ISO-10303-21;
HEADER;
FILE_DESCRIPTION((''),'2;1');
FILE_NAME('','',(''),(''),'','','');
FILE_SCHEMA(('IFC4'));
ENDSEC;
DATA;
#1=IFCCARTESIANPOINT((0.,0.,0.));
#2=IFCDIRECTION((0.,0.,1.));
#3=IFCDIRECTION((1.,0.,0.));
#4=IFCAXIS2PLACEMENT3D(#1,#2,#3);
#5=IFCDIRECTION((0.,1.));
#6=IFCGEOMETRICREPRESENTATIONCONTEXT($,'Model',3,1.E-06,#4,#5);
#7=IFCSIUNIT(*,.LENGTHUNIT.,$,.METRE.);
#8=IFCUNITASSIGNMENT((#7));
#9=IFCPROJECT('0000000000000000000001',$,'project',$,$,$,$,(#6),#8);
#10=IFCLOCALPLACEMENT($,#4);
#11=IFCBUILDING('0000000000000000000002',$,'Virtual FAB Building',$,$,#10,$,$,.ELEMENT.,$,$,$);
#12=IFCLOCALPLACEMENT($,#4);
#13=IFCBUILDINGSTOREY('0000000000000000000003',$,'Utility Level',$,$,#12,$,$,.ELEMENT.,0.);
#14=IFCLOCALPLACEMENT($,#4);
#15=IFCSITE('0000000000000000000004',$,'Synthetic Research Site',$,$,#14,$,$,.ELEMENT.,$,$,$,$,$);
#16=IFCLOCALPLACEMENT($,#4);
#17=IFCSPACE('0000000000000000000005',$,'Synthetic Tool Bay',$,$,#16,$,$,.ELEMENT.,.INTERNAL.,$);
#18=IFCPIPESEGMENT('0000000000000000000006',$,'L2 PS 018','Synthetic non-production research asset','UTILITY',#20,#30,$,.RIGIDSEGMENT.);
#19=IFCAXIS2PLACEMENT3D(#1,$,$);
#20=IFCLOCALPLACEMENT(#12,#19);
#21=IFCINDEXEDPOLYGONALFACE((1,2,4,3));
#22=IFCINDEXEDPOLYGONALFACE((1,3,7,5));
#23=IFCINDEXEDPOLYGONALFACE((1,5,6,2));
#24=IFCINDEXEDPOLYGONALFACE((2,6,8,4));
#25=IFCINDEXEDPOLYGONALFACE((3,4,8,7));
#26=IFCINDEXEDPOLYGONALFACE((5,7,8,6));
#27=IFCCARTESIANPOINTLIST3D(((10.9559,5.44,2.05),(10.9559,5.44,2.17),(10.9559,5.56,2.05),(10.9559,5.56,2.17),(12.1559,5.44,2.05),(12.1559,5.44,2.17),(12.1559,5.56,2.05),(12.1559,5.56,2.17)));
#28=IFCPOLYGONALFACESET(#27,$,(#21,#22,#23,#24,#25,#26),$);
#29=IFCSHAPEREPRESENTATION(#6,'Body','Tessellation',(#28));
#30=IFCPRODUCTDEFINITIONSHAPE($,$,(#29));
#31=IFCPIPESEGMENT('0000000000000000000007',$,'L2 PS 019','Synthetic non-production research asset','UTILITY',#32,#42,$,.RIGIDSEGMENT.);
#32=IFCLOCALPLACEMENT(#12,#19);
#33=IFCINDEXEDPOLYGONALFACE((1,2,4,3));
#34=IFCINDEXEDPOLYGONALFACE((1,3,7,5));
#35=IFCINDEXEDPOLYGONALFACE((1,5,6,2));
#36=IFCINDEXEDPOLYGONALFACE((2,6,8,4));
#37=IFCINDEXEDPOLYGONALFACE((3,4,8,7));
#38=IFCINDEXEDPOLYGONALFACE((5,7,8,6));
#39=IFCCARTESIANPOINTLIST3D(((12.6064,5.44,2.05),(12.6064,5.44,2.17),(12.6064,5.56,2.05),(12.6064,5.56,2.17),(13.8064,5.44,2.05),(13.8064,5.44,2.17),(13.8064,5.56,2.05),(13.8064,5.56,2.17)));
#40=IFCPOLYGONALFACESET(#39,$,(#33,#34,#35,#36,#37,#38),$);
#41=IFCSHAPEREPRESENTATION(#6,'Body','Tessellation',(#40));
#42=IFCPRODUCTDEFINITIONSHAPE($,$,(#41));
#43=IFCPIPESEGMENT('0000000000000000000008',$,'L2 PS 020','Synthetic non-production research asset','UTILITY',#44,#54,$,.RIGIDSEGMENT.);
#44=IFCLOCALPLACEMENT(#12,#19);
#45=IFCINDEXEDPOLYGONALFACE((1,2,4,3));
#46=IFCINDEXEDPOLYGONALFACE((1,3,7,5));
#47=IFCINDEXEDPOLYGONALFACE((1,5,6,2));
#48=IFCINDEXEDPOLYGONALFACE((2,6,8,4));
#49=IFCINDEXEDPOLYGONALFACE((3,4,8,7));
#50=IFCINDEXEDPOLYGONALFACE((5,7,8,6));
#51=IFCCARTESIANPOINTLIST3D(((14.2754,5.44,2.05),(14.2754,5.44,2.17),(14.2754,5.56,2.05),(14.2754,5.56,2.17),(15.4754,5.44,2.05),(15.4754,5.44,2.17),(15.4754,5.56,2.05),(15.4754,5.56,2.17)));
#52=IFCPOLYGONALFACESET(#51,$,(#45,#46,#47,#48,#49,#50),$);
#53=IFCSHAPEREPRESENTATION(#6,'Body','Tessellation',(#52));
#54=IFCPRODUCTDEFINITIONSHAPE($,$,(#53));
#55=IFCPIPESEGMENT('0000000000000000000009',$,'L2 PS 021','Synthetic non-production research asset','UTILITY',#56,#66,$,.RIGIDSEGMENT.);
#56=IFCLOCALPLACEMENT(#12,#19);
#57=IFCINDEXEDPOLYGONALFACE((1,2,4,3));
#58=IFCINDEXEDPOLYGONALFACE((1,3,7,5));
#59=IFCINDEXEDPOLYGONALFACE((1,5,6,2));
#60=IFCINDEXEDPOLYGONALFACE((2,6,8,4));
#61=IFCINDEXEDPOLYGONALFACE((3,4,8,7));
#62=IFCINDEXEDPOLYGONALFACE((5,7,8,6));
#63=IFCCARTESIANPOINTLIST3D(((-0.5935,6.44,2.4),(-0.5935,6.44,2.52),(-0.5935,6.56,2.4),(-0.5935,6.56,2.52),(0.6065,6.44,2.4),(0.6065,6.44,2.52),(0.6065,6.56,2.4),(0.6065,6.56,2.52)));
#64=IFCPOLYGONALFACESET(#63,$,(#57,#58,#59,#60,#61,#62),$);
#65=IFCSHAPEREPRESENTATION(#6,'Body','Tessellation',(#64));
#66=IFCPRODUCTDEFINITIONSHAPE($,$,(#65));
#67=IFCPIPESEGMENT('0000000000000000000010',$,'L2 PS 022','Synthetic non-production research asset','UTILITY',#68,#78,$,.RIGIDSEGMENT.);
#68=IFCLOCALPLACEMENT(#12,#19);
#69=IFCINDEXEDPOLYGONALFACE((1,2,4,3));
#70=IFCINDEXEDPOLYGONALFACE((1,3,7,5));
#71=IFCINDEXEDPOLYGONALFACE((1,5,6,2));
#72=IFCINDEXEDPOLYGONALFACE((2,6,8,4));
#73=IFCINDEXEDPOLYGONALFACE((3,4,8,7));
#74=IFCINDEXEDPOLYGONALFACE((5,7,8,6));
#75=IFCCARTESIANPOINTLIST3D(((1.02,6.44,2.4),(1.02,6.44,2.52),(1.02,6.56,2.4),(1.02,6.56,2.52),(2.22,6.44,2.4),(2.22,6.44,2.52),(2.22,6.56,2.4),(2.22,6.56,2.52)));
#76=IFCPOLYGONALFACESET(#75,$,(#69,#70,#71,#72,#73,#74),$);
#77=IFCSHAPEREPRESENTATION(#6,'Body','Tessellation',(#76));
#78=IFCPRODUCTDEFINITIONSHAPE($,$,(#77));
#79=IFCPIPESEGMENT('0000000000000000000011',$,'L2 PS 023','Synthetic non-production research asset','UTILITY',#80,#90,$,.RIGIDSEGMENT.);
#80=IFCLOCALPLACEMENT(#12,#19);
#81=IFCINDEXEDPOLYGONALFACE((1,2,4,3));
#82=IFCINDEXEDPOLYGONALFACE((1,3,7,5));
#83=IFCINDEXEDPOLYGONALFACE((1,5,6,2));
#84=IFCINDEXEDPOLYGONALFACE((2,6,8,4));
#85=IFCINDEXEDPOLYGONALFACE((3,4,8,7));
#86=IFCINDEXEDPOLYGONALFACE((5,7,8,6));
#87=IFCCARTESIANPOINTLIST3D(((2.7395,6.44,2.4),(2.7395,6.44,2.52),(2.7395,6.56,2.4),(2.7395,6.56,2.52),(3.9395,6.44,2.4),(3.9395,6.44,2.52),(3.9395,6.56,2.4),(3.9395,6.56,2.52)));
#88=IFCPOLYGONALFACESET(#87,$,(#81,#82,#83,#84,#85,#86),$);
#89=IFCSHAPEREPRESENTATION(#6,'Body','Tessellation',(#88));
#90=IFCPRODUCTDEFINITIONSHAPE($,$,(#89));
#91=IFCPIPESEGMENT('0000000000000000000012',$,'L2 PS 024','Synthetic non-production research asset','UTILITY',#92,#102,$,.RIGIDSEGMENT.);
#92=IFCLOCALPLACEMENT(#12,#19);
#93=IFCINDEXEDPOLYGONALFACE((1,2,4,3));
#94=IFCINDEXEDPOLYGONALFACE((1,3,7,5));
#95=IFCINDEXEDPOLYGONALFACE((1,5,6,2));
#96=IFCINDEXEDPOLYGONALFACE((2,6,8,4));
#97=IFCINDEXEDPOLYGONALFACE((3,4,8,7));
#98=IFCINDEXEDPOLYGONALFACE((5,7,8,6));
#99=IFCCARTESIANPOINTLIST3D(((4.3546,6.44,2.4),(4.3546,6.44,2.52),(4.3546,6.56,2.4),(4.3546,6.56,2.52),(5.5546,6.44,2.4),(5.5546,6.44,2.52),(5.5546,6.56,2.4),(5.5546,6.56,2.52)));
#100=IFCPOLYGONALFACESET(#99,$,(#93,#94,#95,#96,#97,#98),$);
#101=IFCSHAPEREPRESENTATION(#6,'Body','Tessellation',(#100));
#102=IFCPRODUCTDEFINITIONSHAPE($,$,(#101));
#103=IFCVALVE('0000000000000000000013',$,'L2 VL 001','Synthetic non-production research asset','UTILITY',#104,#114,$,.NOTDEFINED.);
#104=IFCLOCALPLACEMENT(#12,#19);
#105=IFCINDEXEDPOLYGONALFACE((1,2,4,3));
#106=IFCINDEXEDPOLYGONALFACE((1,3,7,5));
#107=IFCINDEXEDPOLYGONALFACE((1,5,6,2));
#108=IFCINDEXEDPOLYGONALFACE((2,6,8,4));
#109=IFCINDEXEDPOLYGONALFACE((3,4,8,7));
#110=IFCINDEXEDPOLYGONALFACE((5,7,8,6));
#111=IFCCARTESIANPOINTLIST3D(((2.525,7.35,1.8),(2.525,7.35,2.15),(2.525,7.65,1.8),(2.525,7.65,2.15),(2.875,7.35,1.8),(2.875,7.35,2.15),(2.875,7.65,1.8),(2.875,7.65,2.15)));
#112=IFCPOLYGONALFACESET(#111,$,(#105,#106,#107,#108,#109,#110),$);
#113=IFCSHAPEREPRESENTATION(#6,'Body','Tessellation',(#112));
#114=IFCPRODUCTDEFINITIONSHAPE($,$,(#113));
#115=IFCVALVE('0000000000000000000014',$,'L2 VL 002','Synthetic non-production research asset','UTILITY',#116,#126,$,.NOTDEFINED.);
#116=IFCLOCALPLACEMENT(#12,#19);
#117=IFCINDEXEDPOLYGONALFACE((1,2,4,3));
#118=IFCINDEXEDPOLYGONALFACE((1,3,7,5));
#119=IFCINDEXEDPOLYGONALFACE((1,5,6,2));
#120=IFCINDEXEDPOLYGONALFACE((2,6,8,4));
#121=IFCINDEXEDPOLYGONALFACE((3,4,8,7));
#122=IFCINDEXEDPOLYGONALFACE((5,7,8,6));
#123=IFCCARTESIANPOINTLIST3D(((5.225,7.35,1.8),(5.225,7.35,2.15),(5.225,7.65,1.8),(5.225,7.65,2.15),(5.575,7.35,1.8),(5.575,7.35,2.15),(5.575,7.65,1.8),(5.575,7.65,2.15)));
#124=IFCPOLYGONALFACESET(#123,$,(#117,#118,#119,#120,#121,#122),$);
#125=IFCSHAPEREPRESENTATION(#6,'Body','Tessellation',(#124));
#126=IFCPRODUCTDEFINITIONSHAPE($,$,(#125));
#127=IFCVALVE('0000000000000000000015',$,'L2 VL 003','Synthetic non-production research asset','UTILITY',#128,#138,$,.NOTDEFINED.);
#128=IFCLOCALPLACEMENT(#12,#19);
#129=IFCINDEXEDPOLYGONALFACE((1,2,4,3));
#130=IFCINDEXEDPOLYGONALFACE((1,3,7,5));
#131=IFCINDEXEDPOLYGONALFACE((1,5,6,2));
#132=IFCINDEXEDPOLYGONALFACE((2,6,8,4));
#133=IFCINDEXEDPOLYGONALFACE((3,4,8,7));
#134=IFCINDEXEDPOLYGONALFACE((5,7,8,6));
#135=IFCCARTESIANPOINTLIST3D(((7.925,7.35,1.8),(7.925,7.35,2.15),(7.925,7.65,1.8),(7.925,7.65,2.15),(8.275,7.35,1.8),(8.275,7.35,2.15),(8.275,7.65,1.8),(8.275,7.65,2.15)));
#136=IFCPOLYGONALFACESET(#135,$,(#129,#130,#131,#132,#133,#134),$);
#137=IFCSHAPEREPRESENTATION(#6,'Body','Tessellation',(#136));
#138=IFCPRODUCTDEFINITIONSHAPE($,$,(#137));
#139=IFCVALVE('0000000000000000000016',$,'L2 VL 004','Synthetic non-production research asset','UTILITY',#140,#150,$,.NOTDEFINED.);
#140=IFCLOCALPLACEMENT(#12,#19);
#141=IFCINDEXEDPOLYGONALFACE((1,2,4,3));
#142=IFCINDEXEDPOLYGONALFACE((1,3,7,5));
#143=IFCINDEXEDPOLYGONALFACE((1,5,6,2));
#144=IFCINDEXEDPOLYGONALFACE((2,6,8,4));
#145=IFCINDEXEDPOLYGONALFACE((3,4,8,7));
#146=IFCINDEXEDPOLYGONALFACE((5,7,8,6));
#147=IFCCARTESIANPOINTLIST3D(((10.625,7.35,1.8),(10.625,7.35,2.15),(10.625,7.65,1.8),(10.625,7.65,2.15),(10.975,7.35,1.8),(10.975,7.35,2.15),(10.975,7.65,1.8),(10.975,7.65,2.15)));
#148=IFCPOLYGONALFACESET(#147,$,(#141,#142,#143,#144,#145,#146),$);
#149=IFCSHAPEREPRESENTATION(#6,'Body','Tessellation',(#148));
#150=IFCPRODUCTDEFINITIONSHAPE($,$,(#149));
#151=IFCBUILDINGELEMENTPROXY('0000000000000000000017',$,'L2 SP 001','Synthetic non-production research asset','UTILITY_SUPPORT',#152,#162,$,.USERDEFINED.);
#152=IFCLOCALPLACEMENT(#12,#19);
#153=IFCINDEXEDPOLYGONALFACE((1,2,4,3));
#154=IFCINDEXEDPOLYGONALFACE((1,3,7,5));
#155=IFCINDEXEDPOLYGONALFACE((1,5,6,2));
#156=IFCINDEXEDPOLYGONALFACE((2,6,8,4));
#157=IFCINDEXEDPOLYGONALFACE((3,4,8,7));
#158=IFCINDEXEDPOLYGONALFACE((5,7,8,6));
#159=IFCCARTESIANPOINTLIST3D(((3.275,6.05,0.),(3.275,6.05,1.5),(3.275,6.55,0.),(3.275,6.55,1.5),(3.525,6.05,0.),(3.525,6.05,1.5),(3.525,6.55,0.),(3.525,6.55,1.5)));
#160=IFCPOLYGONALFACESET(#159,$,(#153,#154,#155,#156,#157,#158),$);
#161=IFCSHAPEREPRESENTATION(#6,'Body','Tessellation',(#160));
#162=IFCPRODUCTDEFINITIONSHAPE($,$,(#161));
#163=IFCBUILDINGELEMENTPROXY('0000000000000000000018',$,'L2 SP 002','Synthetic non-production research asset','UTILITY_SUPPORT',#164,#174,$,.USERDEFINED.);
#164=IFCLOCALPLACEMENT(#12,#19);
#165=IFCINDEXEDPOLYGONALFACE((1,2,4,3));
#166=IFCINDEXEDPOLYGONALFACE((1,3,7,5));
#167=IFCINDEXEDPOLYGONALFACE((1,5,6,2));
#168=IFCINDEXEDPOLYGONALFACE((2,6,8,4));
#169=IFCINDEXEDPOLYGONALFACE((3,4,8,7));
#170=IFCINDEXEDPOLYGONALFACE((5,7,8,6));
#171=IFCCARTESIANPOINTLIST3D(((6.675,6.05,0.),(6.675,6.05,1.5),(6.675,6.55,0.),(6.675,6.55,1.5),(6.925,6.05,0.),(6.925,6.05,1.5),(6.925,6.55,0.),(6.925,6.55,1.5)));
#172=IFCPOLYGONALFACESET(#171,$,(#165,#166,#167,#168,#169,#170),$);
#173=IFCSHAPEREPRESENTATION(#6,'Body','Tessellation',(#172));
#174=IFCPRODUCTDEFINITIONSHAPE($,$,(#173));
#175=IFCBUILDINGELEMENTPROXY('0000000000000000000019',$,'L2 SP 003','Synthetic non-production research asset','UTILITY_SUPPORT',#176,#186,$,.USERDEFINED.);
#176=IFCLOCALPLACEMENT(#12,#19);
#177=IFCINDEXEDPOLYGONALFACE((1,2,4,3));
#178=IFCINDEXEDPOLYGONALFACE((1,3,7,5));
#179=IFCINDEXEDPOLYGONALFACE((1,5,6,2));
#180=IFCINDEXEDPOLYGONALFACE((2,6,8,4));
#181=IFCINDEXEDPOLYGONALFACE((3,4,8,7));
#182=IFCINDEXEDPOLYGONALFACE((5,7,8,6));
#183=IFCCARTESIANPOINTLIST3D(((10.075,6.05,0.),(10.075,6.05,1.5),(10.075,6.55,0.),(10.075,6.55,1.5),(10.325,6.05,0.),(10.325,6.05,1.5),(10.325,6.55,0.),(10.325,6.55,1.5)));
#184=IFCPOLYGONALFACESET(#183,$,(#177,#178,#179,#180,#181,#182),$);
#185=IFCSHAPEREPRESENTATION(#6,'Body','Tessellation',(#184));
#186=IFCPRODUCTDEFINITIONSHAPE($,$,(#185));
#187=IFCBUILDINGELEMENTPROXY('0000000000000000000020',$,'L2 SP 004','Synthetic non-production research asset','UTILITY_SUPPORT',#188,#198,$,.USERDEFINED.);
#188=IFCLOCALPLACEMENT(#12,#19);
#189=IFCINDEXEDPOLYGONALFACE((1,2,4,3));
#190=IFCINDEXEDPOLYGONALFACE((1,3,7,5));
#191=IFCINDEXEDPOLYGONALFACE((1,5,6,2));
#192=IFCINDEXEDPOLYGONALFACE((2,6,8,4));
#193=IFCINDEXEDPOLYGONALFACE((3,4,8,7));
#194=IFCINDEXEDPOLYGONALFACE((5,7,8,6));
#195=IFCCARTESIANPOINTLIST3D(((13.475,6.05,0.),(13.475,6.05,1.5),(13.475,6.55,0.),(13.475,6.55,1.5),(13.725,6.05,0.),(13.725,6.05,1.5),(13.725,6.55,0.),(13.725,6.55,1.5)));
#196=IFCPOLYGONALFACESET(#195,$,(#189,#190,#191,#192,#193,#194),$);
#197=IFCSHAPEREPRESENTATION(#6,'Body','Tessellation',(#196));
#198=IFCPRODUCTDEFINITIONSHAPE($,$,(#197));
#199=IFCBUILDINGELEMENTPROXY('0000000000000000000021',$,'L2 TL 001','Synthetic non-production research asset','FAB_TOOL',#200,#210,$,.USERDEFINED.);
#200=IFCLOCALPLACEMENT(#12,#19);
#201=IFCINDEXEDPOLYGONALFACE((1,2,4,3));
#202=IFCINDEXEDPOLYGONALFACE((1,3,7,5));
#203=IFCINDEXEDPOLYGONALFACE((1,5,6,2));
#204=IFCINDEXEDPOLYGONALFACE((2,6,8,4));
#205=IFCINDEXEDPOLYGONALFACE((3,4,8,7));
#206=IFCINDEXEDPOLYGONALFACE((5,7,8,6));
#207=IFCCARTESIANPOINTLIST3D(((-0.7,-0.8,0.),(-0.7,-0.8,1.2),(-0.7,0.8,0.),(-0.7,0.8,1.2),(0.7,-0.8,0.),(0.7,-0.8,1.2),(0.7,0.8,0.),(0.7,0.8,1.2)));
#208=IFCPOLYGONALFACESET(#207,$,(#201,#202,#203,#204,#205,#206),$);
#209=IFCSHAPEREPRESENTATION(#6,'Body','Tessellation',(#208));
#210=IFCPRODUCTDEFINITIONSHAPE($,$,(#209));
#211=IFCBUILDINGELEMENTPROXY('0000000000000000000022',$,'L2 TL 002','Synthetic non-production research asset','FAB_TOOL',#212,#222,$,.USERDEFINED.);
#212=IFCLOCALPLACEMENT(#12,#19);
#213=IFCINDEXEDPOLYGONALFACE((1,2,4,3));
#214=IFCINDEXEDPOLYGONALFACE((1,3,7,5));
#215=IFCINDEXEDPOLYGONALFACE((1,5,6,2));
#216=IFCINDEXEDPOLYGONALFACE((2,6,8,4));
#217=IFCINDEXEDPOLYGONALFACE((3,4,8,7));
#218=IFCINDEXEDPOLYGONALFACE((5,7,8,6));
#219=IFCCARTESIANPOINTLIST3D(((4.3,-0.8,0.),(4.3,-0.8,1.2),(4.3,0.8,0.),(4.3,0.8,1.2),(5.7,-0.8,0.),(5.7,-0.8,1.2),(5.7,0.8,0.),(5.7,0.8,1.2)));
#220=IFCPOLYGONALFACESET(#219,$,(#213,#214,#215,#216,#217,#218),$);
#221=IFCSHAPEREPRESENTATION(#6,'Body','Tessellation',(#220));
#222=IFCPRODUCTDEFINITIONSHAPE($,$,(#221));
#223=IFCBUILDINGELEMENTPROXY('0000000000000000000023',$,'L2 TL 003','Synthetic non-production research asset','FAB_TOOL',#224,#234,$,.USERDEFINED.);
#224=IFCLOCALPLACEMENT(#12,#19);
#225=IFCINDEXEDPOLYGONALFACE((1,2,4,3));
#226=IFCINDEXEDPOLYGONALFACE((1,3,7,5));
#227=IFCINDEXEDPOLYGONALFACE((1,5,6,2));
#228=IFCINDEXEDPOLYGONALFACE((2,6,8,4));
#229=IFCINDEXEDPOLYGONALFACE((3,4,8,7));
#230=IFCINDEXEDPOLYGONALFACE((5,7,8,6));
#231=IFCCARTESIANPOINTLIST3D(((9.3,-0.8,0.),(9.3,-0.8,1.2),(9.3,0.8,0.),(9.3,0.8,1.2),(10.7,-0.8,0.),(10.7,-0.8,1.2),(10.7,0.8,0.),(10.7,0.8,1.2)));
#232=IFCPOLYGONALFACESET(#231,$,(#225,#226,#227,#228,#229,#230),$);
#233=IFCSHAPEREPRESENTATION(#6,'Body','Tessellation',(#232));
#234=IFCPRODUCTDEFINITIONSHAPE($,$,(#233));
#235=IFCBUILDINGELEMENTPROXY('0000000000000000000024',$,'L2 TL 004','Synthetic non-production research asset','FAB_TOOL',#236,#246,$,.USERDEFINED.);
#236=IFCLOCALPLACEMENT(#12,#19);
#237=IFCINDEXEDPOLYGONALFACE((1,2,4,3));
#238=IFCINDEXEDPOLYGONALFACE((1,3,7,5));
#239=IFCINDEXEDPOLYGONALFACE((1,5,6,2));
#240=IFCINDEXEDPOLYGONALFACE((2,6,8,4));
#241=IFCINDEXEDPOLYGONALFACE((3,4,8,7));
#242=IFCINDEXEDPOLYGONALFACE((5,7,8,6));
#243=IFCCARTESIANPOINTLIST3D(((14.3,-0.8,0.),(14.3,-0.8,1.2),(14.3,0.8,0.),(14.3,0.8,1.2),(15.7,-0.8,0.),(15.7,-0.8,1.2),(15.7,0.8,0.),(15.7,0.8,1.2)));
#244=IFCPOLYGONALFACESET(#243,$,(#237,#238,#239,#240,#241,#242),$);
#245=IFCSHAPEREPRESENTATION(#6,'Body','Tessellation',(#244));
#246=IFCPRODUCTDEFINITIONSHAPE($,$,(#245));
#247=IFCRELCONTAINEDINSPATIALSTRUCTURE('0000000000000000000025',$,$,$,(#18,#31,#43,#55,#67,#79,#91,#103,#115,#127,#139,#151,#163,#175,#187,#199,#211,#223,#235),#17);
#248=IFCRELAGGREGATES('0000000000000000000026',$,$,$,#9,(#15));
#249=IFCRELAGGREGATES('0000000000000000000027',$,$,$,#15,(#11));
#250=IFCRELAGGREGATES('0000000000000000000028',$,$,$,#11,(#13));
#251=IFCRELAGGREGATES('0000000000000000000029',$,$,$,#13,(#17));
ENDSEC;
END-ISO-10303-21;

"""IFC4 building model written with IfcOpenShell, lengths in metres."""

from ifc_helpers import new_model, si_unit, direction, frame, origin_with_axes, origin_2d_with_axis, place, context, project, spatial, rectangle, extrude, element, save


model = new_model("IFC4")

# Units and contexts
model_context = context("Model", 3, precision=1e-06, world=origin_with_axes(), true_north=direction((0.0, 1.0)))
ifc_project = project(units=[si_unit("LENGTHUNIT", "METRE")], contexts=[model_context])

# Site, building, storey, space
site_placement = place(None, origin_with_axes())
site = spatial("IfcSite", under=ifc_project, at=site_placement, Name="Synthetic Research Site", CompositionType="ELEMENT")
building_placement = place(None, origin_with_axes())
building = spatial("IfcBuilding", under=site, at=building_placement, Name="Virtual FAB Building", CompositionType="ELEMENT")
storey_placement = place(None, origin_with_axes())
storey = spatial("IfcBuildingStorey", under=building, at=storey_placement, Name="Utility Level", CompositionType="ELEMENT", Elevation=0.0)
space_placement = place(None, origin_with_axes())
space = spatial("IfcSpace", under=storey, at=space_placement, Name="Synthetic Tool Bay", CompositionType="ELEMENT", PredefinedType="INTERNAL")

# Pipe segments
for number, where, z_axis, x_axis, name in (
    (1, (11.5559, 5.5, 2.05), (0.0, 0.0, 1.0), (1.0, 0.0, 0.0), "L2 PS 018"),
    (2, (13.2064, 5.5, 2.05), (0.0, 0.0, 1.0), (1.0, 0.0, 0.0), "L2 PS 019"),
    (3, (14.8754, 5.5, 2.05), (0.0, 0.0, 1.0), (1.0, 0.0, 0.0), "L2 PS 020"),
    (4, (0.0065, 6.5, 2.4), (0.0, 0.0, 1.0), (1.0, 0.0, 0.0), "L2 PS 021"),
    (5, (1.62, 6.5, 2.4), (0.0, 0.0, 1.0), (1.0, 0.0, 0.0), "L2 PS 022"),
    (6, (3.3395, 6.5, 2.4), (0.0, 0.0, 1.0), (1.0, 0.0, 0.0), "L2 PS 023"),
    (7, (4.9546, 6.5, 2.4), (0.0, 0.0, 1.0), (1.0, 0.0, 0.0), "L2 PS 024"),
):
    element("IfcPipeSegment", number, at=place(None, frame(where, z_axis=z_axis, x_axis=x_axis)), inside=space, Name=name, Description="Synthetic non-production research asset", ObjectType="UTILITY", PredefinedType="RIGIDSEGMENT", context=model_context, shape_type="SweptSolid", body=[
        extrude(rectangle(XDim=1.2, YDim=0.12, at=origin_2d_with_axis()), origin_with_axes(), (0.0, 0.0, 1.0), 0.12),
    ])

# Valves
for number, where, z_axis, x_axis, name in (
    (8, (2.7, 7.5, 1.8), (0.0, 0.0, 1.0), (1.0, 0.0, 0.0), "L2 VL 001"),
    (9, (5.4, 7.5, 1.8), (0.0, 0.0, 1.0), (1.0, 0.0, 0.0), "L2 VL 002"),
    (10, (8.1, 7.5, 1.8), (0.0, 0.0, 1.0), (1.0, 0.0, 0.0), "L2 VL 003"),
    (11, (10.8, 7.5, 1.8), (0.0, 0.0, 1.0), (1.0, 0.0, 0.0), "L2 VL 004"),
):
    element("IfcValve", number, at=place(None, frame(where, z_axis=z_axis, x_axis=x_axis)), inside=space, Name=name, Description="Synthetic non-production research asset", ObjectType="UTILITY", PredefinedType="NOTDEFINED", context=model_context, shape_type="SweptSolid", body=[
        extrude(rectangle(XDim=0.35, YDim=0.3, at=origin_2d_with_axis()), origin_with_axes(), (0.0, 0.0, 1.0), 0.35),
    ])

# Building element proxies
for number, where, z_axis, x_axis, name in (
    (12, (3.4, 6.3, 0.0), (0.0, 0.0, 1.0), (1.0, 0.0, 0.0), "L2 SP 001"),
    (13, (6.8, 6.3, 0.0), (0.0, 0.0, 1.0), (1.0, 0.0, 0.0), "L2 SP 002"),
    (14, (10.2, 6.3, 0.0), (0.0, 0.0, 1.0), (1.0, 0.0, 0.0), "L2 SP 003"),
    (15, (13.6, 6.3, 0.0), (0.0, 0.0, 1.0), (1.0, 0.0, 0.0), "L2 SP 004"),
):
    element("IfcBuildingElementProxy", number, at=place(None, frame(where, z_axis=z_axis, x_axis=x_axis)), inside=space, Name=name, Description="Synthetic non-production research asset", ObjectType="UTILITY_SUPPORT", PredefinedType="USERDEFINED", context=model_context, shape_type="SweptSolid", body=[
        extrude(rectangle(XDim=0.25, YDim=0.5, at=origin_2d_with_axis()), origin_with_axes(), (0.0, 0.0, 1.0), 1.5),
    ])
for number, where, z_axis, x_axis, name in (
    (16, (0.0, 0.0, 0.0), (0.0, 0.0, 1.0), (1.0, 0.0, 0.0), "L2 TL 001"),
    (17, (5.0, 0.0, 0.0), (0.0, 0.0, 1.0), (1.0, 0.0, 0.0), "L2 TL 002"),
    (18, (10.0, 0.0, 0.0), (0.0, 0.0, 1.0), (1.0, 0.0, 0.0), "L2 TL 003"),
    (19, (15.0, 0.0, 0.0), (0.0, 0.0, 1.0), (1.0, 0.0, 0.0), "L2 TL 004"),
):
    element("IfcBuildingElementProxy", number, at=place(None, frame(where, z_axis=z_axis, x_axis=x_axis)), inside=space, Name=name, Description="Synthetic non-production research asset", ObjectType="FAB_TOOL", PredefinedType="USERDEFINED", context=model_context, shape_type="SweptSolid", body=[
        extrude(rectangle(XDim=1.4, YDim=1.6, at=origin_2d_with_axis()), origin_with_axes(), (0.0, 0.0, 1.0), 1.2),
    ])

save(model, "model.ifc")
